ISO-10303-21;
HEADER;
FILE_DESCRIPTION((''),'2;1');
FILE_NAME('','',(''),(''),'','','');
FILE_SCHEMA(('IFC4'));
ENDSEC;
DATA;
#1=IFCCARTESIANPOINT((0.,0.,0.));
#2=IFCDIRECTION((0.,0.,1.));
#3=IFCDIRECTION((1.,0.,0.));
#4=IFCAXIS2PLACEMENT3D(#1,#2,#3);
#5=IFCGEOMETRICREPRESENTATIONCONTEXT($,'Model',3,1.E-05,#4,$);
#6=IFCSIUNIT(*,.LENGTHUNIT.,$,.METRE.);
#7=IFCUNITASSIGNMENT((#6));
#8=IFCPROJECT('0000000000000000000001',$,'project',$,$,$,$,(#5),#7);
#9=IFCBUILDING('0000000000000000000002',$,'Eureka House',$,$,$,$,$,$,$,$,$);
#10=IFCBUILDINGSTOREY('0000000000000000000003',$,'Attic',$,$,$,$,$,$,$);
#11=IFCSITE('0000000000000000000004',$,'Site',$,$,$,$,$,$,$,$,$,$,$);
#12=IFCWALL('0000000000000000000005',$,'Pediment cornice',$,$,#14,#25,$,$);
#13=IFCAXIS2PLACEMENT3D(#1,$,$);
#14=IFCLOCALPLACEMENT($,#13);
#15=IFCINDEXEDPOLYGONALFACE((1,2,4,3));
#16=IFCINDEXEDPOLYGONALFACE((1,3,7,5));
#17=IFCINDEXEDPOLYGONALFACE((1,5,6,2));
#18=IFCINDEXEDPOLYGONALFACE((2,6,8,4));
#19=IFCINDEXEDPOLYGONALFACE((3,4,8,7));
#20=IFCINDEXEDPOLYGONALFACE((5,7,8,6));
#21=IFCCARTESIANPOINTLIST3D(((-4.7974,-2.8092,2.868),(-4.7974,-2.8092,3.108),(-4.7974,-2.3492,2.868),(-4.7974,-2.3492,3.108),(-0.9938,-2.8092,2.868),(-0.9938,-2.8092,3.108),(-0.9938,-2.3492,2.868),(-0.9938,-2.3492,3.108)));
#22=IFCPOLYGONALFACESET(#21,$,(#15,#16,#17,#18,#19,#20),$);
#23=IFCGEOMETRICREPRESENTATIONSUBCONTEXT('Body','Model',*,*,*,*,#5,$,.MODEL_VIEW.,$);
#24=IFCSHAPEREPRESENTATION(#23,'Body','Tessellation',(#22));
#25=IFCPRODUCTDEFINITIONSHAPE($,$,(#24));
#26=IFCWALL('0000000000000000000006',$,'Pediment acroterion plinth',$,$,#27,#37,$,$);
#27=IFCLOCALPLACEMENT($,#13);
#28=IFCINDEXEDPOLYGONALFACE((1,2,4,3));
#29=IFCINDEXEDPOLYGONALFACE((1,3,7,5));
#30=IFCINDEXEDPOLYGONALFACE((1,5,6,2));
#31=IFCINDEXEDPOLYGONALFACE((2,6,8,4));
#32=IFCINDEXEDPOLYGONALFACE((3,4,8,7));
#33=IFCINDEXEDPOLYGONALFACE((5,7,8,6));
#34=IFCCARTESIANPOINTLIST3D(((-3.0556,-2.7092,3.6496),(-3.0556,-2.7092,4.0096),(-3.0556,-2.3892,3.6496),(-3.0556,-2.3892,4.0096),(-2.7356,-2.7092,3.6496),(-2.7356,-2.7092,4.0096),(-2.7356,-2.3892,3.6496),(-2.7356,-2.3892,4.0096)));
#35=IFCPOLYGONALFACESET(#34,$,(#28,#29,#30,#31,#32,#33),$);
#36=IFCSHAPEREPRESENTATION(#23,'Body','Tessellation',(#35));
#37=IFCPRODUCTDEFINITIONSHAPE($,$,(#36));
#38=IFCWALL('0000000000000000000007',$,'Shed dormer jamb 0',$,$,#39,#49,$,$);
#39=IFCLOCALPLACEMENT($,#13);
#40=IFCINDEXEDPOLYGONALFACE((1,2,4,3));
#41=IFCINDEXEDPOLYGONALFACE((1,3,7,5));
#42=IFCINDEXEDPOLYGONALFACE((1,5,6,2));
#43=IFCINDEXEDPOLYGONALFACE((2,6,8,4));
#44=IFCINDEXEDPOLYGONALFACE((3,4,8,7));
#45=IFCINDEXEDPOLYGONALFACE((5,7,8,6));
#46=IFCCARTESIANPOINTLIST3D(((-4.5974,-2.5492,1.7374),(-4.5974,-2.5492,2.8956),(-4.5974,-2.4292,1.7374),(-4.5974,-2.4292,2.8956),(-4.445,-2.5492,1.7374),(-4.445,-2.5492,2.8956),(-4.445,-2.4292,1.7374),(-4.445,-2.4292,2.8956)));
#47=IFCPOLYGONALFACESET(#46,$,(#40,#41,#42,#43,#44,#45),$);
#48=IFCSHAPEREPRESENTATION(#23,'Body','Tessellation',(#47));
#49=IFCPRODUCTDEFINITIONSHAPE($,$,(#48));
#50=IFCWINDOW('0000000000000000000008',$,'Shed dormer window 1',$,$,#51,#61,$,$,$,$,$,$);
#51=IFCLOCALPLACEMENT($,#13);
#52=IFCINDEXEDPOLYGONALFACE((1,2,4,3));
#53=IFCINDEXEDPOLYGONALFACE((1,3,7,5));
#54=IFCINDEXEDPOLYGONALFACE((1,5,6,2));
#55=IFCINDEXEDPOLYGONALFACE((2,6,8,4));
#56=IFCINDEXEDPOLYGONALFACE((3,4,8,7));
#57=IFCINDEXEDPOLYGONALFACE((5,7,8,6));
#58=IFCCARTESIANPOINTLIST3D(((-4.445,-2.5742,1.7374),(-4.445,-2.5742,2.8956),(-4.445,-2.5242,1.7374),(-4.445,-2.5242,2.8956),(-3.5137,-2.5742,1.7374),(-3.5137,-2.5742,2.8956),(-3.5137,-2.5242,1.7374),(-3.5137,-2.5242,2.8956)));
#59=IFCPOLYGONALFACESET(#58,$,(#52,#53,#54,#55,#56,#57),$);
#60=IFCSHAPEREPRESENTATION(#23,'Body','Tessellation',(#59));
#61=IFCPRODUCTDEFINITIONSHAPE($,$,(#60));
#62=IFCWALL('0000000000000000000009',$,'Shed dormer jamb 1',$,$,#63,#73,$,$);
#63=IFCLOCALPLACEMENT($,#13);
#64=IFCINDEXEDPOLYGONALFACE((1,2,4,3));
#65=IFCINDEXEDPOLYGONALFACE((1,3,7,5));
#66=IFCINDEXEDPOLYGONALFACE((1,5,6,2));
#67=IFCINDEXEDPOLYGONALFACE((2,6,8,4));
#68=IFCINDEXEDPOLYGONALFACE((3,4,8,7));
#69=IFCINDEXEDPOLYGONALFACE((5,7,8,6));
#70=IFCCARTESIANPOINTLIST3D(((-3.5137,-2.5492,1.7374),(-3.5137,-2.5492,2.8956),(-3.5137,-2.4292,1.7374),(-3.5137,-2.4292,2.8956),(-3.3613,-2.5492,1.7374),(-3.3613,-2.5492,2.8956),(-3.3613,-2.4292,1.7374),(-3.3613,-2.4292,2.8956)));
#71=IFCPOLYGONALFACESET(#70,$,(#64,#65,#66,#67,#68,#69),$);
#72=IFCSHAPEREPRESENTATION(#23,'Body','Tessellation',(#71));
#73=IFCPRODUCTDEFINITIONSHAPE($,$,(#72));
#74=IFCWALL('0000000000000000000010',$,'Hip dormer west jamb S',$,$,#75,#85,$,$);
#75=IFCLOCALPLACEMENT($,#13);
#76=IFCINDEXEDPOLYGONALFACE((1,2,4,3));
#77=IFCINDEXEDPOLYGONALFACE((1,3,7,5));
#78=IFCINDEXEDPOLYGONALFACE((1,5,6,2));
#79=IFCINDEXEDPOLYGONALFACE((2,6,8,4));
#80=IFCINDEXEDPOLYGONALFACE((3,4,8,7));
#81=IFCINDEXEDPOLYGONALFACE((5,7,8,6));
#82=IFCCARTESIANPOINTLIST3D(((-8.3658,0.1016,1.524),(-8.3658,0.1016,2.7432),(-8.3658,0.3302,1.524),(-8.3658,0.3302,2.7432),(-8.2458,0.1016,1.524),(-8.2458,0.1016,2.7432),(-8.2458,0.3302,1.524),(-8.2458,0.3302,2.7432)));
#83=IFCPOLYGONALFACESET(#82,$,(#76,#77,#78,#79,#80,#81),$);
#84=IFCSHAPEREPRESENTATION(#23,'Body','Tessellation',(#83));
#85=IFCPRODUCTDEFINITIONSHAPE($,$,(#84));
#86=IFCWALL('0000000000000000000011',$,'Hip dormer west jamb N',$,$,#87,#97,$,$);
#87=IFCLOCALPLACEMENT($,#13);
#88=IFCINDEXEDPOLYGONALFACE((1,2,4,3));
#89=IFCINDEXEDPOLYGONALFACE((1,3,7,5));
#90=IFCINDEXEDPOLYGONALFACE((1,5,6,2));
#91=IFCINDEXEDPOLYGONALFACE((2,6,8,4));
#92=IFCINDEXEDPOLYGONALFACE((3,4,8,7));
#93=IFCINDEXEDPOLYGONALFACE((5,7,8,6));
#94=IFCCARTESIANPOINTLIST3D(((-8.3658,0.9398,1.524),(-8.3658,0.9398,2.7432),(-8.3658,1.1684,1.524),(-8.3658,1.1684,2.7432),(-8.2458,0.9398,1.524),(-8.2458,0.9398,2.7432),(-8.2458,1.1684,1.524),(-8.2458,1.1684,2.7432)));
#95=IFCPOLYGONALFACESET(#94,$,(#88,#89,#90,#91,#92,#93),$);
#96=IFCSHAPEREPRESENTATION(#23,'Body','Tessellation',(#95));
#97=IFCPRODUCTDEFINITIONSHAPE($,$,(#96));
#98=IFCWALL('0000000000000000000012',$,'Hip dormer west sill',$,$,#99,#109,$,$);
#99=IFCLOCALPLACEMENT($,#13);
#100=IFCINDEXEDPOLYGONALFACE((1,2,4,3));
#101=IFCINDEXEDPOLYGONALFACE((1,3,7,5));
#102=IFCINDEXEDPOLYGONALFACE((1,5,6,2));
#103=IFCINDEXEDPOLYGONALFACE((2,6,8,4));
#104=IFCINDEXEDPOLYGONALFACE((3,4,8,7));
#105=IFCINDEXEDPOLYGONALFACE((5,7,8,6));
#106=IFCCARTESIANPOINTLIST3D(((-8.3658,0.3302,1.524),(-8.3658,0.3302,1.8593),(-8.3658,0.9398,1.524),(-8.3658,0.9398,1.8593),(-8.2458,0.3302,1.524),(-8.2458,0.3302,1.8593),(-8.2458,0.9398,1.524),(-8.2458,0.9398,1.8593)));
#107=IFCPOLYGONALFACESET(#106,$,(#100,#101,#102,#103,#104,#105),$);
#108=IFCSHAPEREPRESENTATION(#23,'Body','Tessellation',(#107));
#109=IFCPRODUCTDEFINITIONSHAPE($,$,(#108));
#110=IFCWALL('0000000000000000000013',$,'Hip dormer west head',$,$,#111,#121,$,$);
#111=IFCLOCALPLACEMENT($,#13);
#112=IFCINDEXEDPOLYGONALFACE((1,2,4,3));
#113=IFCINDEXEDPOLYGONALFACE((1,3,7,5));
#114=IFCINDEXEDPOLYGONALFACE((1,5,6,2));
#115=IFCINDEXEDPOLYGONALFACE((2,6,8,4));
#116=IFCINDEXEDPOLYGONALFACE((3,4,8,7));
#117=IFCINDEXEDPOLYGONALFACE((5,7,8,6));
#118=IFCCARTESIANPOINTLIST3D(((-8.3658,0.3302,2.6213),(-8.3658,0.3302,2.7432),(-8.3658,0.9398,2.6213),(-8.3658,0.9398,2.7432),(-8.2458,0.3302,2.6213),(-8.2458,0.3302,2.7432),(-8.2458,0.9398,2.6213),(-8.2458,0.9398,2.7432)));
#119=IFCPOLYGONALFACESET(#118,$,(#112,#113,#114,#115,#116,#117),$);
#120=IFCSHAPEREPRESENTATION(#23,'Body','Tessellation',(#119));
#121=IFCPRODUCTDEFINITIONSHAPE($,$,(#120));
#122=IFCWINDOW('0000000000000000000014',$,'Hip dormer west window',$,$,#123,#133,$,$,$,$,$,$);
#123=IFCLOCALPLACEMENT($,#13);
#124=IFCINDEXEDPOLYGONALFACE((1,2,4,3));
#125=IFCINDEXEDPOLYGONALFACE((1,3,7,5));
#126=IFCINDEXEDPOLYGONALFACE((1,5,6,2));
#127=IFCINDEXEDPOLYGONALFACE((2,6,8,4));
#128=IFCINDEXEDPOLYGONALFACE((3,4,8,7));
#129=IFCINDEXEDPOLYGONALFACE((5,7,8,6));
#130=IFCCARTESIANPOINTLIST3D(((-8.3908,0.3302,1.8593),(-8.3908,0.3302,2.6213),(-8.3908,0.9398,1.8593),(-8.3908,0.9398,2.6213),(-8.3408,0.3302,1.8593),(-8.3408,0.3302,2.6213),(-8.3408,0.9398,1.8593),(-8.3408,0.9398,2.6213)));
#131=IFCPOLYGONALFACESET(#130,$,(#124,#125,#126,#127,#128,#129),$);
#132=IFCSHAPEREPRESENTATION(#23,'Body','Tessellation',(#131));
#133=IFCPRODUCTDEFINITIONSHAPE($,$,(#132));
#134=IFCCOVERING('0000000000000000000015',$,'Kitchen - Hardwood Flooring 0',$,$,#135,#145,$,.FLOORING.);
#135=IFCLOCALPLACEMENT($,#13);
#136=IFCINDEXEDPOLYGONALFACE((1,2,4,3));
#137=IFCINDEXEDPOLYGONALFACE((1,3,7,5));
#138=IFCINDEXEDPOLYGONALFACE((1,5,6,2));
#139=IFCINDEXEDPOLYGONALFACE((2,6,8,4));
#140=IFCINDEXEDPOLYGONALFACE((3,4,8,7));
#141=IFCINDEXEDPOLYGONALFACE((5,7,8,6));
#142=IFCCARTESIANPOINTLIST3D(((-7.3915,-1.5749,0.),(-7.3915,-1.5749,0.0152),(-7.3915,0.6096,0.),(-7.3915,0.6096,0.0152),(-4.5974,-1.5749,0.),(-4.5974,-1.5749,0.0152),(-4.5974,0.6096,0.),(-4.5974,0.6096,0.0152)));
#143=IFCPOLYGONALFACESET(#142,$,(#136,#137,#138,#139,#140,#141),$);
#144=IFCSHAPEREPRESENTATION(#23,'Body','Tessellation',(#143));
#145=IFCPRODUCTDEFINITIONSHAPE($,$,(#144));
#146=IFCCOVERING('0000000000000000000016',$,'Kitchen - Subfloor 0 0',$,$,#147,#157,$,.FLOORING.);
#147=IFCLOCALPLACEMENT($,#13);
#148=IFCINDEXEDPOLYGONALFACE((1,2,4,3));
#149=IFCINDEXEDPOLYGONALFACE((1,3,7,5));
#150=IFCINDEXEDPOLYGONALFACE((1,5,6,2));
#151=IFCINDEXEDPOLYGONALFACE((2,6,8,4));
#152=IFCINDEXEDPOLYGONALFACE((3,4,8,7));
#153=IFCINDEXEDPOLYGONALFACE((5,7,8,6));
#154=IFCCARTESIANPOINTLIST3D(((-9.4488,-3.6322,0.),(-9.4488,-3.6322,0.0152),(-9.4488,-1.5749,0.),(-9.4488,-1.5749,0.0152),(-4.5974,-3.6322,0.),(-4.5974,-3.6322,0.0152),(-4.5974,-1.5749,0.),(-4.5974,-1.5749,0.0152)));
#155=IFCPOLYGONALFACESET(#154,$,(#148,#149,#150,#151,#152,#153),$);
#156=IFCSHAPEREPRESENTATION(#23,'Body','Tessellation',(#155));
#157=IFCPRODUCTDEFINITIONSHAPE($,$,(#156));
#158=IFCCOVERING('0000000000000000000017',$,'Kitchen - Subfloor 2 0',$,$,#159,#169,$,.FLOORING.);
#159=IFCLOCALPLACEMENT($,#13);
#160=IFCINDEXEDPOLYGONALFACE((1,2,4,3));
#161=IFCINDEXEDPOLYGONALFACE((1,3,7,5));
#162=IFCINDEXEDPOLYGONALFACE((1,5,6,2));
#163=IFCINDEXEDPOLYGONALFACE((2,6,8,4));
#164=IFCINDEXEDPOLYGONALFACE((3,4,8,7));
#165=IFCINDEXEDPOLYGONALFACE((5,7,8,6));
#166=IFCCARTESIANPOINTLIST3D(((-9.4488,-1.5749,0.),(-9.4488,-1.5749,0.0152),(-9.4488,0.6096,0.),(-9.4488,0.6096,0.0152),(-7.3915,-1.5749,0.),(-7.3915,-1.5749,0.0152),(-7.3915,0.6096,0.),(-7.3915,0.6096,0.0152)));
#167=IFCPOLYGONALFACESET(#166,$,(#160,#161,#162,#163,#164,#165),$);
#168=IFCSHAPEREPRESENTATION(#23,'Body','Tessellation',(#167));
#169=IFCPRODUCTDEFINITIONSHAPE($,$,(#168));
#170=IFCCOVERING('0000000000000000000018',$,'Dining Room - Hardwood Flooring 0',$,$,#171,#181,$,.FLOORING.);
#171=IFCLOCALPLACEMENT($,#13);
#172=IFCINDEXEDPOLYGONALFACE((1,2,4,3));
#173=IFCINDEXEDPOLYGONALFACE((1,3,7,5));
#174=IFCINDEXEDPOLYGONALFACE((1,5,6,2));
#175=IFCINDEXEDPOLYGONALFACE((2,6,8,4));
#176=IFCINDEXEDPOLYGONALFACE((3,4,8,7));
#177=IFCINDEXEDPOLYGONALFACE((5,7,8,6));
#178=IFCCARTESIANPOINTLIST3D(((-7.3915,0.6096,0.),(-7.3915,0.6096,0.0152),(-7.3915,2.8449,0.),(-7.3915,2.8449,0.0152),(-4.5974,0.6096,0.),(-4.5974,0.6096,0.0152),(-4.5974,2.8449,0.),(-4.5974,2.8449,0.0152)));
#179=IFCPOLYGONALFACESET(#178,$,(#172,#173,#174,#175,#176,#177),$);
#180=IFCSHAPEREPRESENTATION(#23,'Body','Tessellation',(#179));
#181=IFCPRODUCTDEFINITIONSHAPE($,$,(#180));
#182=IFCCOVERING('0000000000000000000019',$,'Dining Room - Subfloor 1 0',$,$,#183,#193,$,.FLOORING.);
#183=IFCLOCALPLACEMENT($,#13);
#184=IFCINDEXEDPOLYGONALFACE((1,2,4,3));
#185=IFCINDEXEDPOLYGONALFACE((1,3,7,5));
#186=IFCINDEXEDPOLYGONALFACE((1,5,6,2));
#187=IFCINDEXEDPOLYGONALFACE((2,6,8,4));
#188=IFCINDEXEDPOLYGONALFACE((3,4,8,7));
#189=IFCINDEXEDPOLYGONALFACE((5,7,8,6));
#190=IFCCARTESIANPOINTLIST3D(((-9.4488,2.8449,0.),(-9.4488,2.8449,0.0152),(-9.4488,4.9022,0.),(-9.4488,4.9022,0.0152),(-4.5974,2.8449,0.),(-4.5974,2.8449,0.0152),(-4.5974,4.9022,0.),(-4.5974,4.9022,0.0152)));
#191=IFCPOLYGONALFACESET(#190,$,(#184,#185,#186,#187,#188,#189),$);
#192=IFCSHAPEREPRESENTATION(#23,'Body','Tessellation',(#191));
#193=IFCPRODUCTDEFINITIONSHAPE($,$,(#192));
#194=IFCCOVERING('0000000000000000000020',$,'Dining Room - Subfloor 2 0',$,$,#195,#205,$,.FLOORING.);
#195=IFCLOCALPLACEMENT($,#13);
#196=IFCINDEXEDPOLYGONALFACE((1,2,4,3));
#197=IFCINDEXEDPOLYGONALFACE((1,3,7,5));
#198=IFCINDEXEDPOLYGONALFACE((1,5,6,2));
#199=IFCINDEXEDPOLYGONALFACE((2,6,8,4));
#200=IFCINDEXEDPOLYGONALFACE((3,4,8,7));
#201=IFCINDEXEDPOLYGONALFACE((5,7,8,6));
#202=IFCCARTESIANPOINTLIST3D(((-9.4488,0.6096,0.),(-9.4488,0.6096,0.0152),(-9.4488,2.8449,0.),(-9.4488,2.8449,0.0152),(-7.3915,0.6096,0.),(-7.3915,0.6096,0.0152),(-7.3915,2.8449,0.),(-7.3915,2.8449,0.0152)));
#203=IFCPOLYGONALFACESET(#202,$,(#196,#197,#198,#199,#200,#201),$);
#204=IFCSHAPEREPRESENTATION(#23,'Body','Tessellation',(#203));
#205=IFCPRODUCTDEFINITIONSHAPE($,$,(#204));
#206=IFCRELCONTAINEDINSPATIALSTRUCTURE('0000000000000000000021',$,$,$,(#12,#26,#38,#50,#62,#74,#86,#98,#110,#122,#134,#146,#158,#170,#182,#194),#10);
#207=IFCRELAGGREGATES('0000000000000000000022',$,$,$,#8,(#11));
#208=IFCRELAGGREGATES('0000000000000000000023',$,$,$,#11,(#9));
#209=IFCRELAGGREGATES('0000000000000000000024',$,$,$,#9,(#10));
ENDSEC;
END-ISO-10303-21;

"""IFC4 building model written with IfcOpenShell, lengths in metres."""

from ifc_helpers import new_model, si_unit, frame, origin, origin_with_axes, origin_2d, place, context, subcontext, project, spatial, rectangle, extrude, element, save


model = new_model("IFC4")

# Units and contexts
model_context = context("Model", 3, precision=1e-05, world=origin_with_axes())
body_context = subcontext(model_context, "Body", "Model", "MODEL_VIEW")
ifc_project = project(units=[si_unit("LENGTHUNIT", "METRE")], contexts=[model_context])

# Site, building, storey
site = spatial("IfcSite", under=ifc_project, Name="Site")
building = spatial("IfcBuilding", under=site, Name="Eureka House")
storey = spatial("IfcBuildingStorey", under=building, Name="Attic")

# Walls
wall_1_placement = place(None, frame((-2.8956, -2.5792, 2.868), z_axis=(0.0, 0.0, 1.0), x_axis=(1.0, 0.0, 0.0)))
element("IfcWall", 1, at=wall_1_placement, inside=storey, Name="Pediment cornice", context=body_context, shape_type="SweptSolid", body=[
    extrude(rectangle(XDim=3.8036, YDim=0.46, at=origin_2d()), origin(), (0.0, 0.0, 1.0), 0.24),
])
wall_2_placement = place(None, frame((-2.8956, -2.5492, 3.6496), z_axis=(0.0, 0.0, 1.0), x_axis=(1.0, 0.0, 0.0)))
element("IfcWall", 2, at=wall_2_placement, inside=storey, Name="Pediment acroterion plinth", context=body_context, shape_type="SweptSolid", body=[
    extrude(rectangle(XDim=0.32, YDim=0.32, at=origin_2d()), origin(), (0.0, 0.0, 1.0), 0.36),
])
wall_3_placement = place(None, frame((-4.5212, -2.4892, 1.7374), z_axis=(0.0, 0.0, 1.0), x_axis=(1.0, 0.0, 0.0)))
element("IfcWall", 3, at=wall_3_placement, inside=storey, Name="Shed dormer jamb 0", context=body_context, shape_type="SweptSolid", body=[
    extrude(rectangle(XDim=0.1524, YDim=0.12, at=origin_2d()), origin(), (0.0, 0.0, 1.0), 1.1582),
])

# Window
window_1_placement = place(None, frame((-3.9793, -2.5492, 1.7374), z_axis=(0.0, 0.0, 1.0), x_axis=(1.0, 0.0, 0.0)))
element("IfcWindow", 4, at=window_1_placement, inside=storey, Name="Shed dormer window 1", context=body_context, shape_type="SweptSolid", body=[
    extrude(rectangle(XDim=0.9313, YDim=0.05, at=origin_2d()), origin(), (0.0, 0.0, 1.0), 1.1582),
])

# Walls
wall_4_placement = place(None, frame((-3.4375, -2.4892, 1.7374), z_axis=(0.0, 0.0, 1.0), x_axis=(1.0, 0.0, 0.0)))
element("IfcWall", 5, at=wall_4_placement, inside=storey, Name="Shed dormer jamb 1", context=body_context, shape_type="SweptSolid", body=[
    extrude(rectangle(XDim=0.1524, YDim=0.12, at=origin_2d()), origin(), (0.0, 0.0, 1.0), 1.1582),
])
wall_5_placement = place(None, frame((-8.3058, 0.2159, 1.524), z_axis=(0.0, 0.0, 1.0), x_axis=(1.0, 0.0, 0.0)))
element("IfcWall", 6, at=wall_5_placement, inside=storey, Name="Hip dormer west jamb S", context=body_context, shape_type="SweptSolid", body=[
    extrude(rectangle(XDim=0.12, YDim=0.2286, at=origin_2d()), origin(), (0.0, 0.0, 1.0), 1.2192),
])
wall_6_placement = place(None, frame((-8.3058, 1.0541, 1.524), z_axis=(0.0, 0.0, 1.0), x_axis=(1.0, 0.0, 0.0)))
element("IfcWall", 7, at=wall_6_placement, inside=storey, Name="Hip dormer west jamb N", context=body_context, shape_type="SweptSolid", body=[
    extrude(rectangle(XDim=0.12, YDim=0.2286, at=origin_2d()), origin(), (0.0, 0.0, 1.0), 1.2192),
])
wall_7_placement = place(None, frame((-8.3058, 0.635, 1.524), z_axis=(0.0, 0.0, 1.0), x_axis=(1.0, 0.0, 0.0)))
element("IfcWall", 8, at=wall_7_placement, inside=storey, Name="Hip dormer west sill", context=body_context, shape_type="SweptSolid", body=[
    extrude(rectangle(XDim=0.12, YDim=0.6096, at=origin_2d()), origin(), (0.0, 0.0, 1.0), 0.3353),
])
wall_8_placement = place(None, frame((-8.3058, 0.635, 2.6213), z_axis=(0.0, 0.0, 1.0), x_axis=(1.0, 0.0, 0.0)))
element("IfcWall", 9, at=wall_8_placement, inside=storey, Name="Hip dormer west head", context=body_context, shape_type="SweptSolid", body=[
    extrude(rectangle(XDim=0.12, YDim=0.6096, at=origin_2d()), origin(), (0.0, 0.0, 1.0), 0.1219),
])

# Window
window_2_placement = place(None, frame((-8.3658, 0.635, 1.8593), z_axis=(0.0, 0.0, 1.0), x_axis=(1.0, 0.0, 0.0)))
element("IfcWindow", 10, at=window_2_placement, inside=storey, Name="Hip dormer west window", context=body_context, shape_type="SweptSolid", body=[
    extrude(rectangle(XDim=0.05, YDim=0.6096, at=origin_2d()), origin(), (0.0, 0.0, 1.0), 0.762),
])

# Coverings
covering_1_placement = place(None, frame((-5.9944, -0.4827, 0.0), z_axis=(0.0, 0.0, 1.0), x_axis=(1.0, 0.0, 0.0)))
element("IfcCovering", 11, at=covering_1_placement, inside=storey, Name="Kitchen - Hardwood Flooring 0", PredefinedType="FLOORING", context=body_context, shape_type="SweptSolid", body=[
    extrude(rectangle(XDim=2.7941, YDim=2.1845, at=origin_2d()), origin(), (0.0, 0.0, 1.0), 0.0152),
])
covering_2_placement = place(None, frame((-7.0231, -2.6036, 0.0), z_axis=(0.0, 0.0, 1.0), x_axis=(1.0, 0.0, 0.0)))
element("IfcCovering", 12, at=covering_2_placement, inside=storey, Name="Kitchen - Subfloor 0 0", PredefinedType="FLOORING", context=body_context, shape_type="SweptSolid", body=[
    extrude(rectangle(XDim=4.8514, YDim=2.0573, at=origin_2d()), origin(), (0.0, 0.0, 1.0), 0.0152),
])
covering_3_placement = place(None, frame((-8.4202, -0.4827, 0.0), z_axis=(0.0, 0.0, 1.0), x_axis=(1.0, 0.0, 0.0)))
element("IfcCovering", 13, at=covering_3_placement, inside=storey, Name="Kitchen - Subfloor 2 0", PredefinedType="FLOORING", context=body_context, shape_type="SweptSolid", body=[
    extrude(rectangle(XDim=2.0573, YDim=2.1845, at=origin_2d()), origin(), (0.0, 0.0, 1.0), 0.0152),
])
covering_4_placement = place(None, frame((-5.9944, 1.7272, 0.0), z_axis=(0.0, 0.0, 1.0), x_axis=(1.0, 0.0, 0.0)))
element("IfcCovering", 14, at=covering_4_placement, inside=storey, Name="Dining Room - Hardwood Flooring 0", PredefinedType="FLOORING", context=body_context, shape_type="SweptSolid", body=[
    extrude(rectangle(XDim=2.7941, YDim=2.2353, at=origin_2d()), origin(), (0.0, 0.0, 1.0), 0.0152),
])
covering_5_placement = place(None, frame((-7.0231, 3.8735, 0.0), z_axis=(0.0, 0.0, 1.0), x_axis=(1.0, 0.0, 0.0)))
element("IfcCovering", 15, at=covering_5_placement, inside=storey, Name="Dining Room - Subfloor 1 0", PredefinedType="FLOORING", context=body_context, shape_type="SweptSolid", body=[
    extrude(rectangle(XDim=4.8514, YDim=2.0573, at=origin_2d()), origin(), (0.0, 0.0, 1.0), 0.0152),
])
covering_6_placement = place(None, frame((-8.4202, 1.7272, 0.0), z_axis=(0.0, 0.0, 1.0), x_axis=(1.0, 0.0, 0.0)))
element("IfcCovering", 16, at=covering_6_placement, inside=storey, Name="Dining Room - Subfloor 2 0", PredefinedType="FLOORING", context=body_context, shape_type="SweptSolid", body=[
    extrude(rectangle(XDim=2.0573, YDim=2.2353, at=origin_2d()), origin(), (0.0, 0.0, 1.0), 0.0152),
])

save(model, "model.ifc")
